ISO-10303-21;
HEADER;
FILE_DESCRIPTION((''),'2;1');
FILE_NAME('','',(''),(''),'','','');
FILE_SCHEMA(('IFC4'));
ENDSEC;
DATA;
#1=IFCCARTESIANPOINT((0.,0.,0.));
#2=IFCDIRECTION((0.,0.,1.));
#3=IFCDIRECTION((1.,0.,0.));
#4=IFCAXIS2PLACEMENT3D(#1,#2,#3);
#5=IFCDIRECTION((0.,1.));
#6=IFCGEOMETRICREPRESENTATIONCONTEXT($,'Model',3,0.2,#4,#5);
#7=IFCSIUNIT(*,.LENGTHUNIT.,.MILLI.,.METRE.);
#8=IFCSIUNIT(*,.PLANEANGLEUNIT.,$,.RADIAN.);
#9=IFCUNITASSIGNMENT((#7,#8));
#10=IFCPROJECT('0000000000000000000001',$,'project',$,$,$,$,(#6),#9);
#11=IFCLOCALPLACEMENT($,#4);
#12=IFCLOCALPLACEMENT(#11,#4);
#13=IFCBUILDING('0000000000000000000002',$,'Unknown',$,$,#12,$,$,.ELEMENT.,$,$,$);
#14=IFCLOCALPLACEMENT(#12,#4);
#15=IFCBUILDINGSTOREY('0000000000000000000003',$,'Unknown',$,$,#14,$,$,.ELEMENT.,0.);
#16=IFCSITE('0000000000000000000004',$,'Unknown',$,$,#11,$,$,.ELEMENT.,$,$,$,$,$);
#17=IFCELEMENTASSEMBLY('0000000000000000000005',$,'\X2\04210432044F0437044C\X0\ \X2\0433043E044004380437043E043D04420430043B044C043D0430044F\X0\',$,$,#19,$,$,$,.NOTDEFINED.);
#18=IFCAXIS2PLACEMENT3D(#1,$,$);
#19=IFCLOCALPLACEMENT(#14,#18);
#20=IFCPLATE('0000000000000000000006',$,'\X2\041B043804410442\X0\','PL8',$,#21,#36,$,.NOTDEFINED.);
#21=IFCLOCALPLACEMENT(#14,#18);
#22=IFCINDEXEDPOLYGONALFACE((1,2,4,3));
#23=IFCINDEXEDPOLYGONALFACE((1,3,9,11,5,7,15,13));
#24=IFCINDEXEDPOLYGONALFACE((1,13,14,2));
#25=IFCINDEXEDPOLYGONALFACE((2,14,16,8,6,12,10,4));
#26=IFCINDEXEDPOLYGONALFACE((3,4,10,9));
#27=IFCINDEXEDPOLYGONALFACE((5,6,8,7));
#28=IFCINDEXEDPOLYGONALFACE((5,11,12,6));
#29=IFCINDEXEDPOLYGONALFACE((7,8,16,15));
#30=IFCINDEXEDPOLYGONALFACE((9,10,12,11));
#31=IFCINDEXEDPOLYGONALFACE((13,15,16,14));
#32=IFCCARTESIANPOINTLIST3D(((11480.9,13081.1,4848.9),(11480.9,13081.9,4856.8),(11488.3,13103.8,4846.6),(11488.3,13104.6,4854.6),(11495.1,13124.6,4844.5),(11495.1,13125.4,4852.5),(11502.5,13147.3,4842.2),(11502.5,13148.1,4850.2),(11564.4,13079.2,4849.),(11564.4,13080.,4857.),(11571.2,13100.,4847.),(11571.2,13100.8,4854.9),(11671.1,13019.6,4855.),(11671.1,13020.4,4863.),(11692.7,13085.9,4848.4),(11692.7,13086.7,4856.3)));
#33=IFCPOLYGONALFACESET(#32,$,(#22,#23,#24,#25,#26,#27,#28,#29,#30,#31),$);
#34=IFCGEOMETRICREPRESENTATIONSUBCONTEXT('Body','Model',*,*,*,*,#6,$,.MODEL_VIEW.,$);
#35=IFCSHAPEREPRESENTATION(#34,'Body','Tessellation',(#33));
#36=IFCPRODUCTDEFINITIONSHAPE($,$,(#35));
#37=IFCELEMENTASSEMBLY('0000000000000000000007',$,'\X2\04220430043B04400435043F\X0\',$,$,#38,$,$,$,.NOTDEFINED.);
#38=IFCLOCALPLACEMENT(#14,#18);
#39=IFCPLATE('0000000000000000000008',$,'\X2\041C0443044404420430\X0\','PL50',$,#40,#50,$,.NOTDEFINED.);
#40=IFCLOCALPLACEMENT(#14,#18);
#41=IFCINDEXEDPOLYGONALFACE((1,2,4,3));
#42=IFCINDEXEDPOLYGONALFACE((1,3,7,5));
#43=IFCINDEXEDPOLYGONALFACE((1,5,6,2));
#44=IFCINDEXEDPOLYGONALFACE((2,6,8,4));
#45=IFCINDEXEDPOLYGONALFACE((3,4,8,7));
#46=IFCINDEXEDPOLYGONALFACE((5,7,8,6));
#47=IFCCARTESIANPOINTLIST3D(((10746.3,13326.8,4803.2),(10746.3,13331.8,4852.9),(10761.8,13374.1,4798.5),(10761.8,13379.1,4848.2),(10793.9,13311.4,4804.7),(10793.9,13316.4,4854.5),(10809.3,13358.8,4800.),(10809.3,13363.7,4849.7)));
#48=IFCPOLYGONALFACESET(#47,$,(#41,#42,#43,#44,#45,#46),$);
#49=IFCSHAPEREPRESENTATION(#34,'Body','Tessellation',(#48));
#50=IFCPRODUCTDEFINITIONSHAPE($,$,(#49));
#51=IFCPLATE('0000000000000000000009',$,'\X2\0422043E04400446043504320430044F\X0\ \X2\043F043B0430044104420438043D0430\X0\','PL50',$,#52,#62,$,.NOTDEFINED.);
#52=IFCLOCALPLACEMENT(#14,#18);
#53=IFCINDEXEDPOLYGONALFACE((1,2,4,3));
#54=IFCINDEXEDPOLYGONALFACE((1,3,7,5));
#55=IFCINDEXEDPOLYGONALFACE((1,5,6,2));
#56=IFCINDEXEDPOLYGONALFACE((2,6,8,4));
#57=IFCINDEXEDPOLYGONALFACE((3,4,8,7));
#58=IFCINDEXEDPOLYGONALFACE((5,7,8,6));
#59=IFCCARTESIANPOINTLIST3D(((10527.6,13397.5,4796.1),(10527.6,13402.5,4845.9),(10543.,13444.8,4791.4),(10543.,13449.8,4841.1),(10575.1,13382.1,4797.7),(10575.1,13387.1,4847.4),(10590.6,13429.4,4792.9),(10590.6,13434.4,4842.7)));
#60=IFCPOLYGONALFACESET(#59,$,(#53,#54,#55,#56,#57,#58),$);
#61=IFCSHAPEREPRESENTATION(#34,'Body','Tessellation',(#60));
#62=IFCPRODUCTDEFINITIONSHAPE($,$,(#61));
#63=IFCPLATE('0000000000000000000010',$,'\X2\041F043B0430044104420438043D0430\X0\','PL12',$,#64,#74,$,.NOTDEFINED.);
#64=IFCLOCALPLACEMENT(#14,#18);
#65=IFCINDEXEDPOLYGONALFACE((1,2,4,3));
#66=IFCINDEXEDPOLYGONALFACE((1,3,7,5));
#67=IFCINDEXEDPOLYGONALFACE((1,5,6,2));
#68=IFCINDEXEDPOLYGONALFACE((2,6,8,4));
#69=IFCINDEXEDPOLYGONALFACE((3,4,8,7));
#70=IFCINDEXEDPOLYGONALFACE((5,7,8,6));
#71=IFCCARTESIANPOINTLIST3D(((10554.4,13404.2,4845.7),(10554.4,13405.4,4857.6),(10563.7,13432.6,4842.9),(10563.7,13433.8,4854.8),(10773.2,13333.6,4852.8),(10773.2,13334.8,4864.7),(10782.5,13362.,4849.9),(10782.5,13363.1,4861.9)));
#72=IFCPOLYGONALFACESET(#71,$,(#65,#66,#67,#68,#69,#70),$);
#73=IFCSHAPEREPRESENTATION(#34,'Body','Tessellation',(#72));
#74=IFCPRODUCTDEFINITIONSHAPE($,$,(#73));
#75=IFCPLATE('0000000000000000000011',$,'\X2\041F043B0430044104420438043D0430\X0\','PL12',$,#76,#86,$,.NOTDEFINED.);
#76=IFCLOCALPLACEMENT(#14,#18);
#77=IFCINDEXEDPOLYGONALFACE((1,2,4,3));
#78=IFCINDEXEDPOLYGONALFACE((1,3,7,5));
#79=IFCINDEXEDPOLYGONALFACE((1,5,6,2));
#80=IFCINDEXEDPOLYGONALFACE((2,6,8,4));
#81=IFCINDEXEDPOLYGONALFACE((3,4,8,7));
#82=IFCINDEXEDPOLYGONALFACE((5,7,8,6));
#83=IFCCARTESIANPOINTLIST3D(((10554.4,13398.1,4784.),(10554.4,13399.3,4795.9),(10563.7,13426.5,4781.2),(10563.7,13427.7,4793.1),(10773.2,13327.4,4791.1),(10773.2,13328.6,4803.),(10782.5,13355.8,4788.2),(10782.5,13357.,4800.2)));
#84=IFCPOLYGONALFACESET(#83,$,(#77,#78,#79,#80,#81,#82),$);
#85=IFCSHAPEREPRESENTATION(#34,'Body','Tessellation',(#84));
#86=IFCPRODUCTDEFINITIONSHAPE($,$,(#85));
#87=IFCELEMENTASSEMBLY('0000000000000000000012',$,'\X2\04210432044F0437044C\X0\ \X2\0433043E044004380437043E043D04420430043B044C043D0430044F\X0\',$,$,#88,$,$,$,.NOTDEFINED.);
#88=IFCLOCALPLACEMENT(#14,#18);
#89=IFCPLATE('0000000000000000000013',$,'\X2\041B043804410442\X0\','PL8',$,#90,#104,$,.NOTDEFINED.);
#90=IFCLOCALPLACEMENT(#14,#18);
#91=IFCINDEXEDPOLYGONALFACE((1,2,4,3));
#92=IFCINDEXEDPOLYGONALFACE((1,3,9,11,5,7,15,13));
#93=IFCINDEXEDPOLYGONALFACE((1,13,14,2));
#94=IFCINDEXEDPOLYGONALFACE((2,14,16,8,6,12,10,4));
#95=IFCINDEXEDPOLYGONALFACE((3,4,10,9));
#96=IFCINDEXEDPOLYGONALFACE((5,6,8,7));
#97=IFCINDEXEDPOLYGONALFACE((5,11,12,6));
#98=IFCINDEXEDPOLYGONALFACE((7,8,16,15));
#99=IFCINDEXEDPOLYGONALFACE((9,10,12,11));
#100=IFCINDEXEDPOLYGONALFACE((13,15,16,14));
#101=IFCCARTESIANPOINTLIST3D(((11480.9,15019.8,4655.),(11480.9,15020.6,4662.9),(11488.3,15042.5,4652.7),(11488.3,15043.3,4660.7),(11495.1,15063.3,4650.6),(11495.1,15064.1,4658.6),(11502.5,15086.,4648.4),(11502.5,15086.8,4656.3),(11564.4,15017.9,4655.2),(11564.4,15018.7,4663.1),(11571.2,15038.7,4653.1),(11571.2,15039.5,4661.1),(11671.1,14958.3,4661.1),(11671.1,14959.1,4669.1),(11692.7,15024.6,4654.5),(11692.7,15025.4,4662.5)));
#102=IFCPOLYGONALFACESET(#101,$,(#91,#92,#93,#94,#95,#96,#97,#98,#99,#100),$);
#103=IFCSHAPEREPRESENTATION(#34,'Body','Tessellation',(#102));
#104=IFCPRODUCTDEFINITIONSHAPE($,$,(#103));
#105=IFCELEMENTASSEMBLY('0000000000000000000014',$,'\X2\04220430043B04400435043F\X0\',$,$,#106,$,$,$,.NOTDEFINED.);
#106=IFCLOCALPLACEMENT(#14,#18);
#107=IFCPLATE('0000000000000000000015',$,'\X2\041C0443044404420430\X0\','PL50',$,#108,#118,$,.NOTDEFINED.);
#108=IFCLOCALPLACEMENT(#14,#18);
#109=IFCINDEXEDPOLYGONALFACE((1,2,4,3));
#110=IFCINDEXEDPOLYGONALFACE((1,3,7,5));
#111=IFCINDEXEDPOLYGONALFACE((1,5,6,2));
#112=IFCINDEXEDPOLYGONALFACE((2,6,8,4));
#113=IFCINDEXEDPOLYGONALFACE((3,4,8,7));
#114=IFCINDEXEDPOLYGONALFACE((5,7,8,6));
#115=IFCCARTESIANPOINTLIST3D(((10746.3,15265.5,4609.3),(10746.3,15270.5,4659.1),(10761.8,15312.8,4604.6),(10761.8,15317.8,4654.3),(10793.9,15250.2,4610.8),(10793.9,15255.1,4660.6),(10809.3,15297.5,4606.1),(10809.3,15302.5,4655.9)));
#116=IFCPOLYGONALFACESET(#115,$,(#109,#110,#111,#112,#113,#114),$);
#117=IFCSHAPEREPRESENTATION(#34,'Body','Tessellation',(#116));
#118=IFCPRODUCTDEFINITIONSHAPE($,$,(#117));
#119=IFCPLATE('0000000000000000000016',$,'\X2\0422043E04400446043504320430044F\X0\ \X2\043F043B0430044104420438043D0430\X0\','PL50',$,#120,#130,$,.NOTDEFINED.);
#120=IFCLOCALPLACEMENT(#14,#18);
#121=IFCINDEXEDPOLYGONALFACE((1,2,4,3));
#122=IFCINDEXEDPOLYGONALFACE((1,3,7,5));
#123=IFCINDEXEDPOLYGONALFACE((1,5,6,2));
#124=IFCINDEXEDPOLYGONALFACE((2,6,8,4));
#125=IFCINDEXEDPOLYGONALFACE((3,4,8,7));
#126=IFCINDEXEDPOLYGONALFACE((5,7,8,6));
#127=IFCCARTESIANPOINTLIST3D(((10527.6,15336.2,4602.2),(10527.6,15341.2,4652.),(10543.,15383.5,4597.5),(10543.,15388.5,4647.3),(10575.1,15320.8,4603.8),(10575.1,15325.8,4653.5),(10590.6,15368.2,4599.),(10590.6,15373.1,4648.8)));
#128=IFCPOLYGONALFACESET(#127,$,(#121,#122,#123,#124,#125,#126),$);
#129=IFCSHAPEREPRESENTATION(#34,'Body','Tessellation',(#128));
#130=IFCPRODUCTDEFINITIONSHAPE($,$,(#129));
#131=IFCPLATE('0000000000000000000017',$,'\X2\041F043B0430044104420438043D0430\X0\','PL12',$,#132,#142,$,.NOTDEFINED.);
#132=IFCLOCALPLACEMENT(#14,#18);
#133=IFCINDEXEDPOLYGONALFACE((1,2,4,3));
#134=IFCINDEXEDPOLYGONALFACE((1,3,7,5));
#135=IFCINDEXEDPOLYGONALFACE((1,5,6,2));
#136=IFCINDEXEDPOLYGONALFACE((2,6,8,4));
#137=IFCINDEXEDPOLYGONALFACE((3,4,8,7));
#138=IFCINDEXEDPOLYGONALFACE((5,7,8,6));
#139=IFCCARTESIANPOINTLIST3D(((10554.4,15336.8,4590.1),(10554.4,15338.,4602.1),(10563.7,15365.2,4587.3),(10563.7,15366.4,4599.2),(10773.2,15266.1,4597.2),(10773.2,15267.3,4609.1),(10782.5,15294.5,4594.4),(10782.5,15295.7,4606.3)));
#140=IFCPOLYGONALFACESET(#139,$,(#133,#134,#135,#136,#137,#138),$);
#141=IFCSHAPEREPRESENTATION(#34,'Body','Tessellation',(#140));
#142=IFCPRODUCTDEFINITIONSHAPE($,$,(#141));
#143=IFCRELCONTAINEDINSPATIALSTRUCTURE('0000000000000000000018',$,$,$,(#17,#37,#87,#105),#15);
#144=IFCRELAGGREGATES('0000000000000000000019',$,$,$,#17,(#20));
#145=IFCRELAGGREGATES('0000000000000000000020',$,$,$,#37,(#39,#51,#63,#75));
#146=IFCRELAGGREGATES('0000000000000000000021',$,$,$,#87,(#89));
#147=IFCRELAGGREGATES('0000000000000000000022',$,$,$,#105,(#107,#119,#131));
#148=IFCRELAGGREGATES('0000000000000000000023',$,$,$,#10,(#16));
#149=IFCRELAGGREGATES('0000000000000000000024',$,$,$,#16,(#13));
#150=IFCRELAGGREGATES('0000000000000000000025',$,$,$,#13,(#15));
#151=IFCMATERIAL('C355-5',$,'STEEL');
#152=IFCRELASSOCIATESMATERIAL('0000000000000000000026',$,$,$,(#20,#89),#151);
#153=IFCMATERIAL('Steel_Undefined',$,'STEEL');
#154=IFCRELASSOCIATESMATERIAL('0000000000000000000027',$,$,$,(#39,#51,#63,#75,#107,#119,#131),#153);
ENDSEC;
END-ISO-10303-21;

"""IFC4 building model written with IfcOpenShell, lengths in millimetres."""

from ifc_helpers import new_model, si_unit, direction, frame, origin_with_axes, place, context, subcontext, project, spatial, line, indexed_curve, outline, extrude, material, element, aggregate, save


model = new_model("IFC4")

# Units and contexts
model_context = context("Model", 3, precision=0.2, world=origin_with_axes(), true_north=direction((0.0, 1.0)))
body_context = subcontext(model_context, "Body", "Model", "MODEL_VIEW")
ifc_project = project(units=[si_unit("LENGTHUNIT", "METRE", prefix="MILLI"), si_unit("PLANEANGLEUNIT", "RADIAN")], contexts=[model_context])

# Site, building, storey
site_placement = place(None, origin_with_axes())
site = spatial("IfcSite", under=ifc_project, at=site_placement, Name="Unknown", CompositionType="ELEMENT")
building_placement = place(site_placement, origin_with_axes())
building = spatial("IfcBuilding", under=site, at=building_placement, Name="Unknown", CompositionType="ELEMENT")
storey_placement = place(building_placement, origin_with_axes())
storey = spatial("IfcBuildingStorey", under=building, at=storey_placement, Name="Unknown", CompositionType="ELEMENT", Elevation=0.0)

# Shared definitions
ifc_material_1 = material(Name="C355-5", Category="STEEL")

# Shared definitions
ifc_material_2 = material(Name="Steel_Undefined", Category="STEEL")

# Element assembly, plate
assembly_1_placement = place(storey_placement, frame((10668.4, 13380.6, 4822.9), z_axis=(-0.308855, -0.946389, 0.094639), x_axis=(0.951109, -0.307322, 0.030732)))
assembly_1 = element("IfcElementAssembly", 1, at=assembly_1_placement, inside=storey, Name="Связь горизонтальная", PredefinedType="NOTDEFINED")
plate_1_placement = place(assembly_1_placement, frame((865.6, 0.0, -35.0), z_axis=(0.0, -1.0, 0.0), x_axis=(1.0, 0.0, 0.0)))
plate_1 = element("IfcPlate", 2, at=plate_1_placement, material=ifc_material_1, Name="Лист", Description="PL8", PredefinedType="NOTDEFINED", context=body_context, shape_type="SolidModel", body=[
    extrude(outline(indexed_curve([(0.0, 0.0), (200.0, 0.0), (200.0, 70.0), (0.0, 70.0), (0.0, 46.0), (80.0, 46.0), (80.0, 24.0), (0.0, 24.0)], segments=[line(1, 2, 3, 4, 5, 6, 7, 8, 1)])), frame((0.0, 0.0, 4.0), z_axis=(0.0, 0.0, 1.0), x_axis=(1.0, 0.0, 0.0)), (0.0, 0.0, -1.0), 8.0),
])
aggregate(assembly_1, [plate_1])

# Element assembly, plates
assembly_2_placement = place(storey_placement, frame((10770.1, 13324.1, 4853.7), z_axis=(-0.951109, 0.307322, -0.030732), x_axis=(0.308855, 0.946389, -0.094639)))
assembly_2 = element("IfcElementAssembly", 3, at=assembly_2_placement, inside=storey, Name="Талреп", PredefinedType="NOTDEFINED")
plate_2_placement = place(assembly_2_placement, origin_with_axes())
plate_2 = element("IfcPlate", 4, at=plate_2_placement, material=ifc_material_2, Name="Муфта", Description="PL50", PredefinedType="NOTDEFINED", context=body_context, shape_type="SolidModel", body=[
    extrude(outline(indexed_curve([(0.0, 0.0), (50.0, 0.0), (50.0, 50.0), (0.0, 50.0)], segments=[line(1, 2, 3, 4, 1)])), frame((0.0, 0.0, 25.0), z_axis=(0.0, 0.0, 1.0), x_axis=(1.0, 0.0, 0.0)), (0.0, 0.0, -1.0), 50.0),
])
plate_3_placement = place(assembly_2_placement, frame((0.0, 0.0, 230.0), z_axis=(0.0, 0.0, 1.0), x_axis=(1.0, 0.0, 0.0)))
plate_3 = element("IfcPlate", 5, at=plate_3_placement, material=ifc_material_2, Name="Торцевая пластина", Description="PL50", PredefinedType="NOTDEFINED", context=body_context, shape_type="SolidModel", body=[
    extrude(outline(indexed_curve([(0.0, 0.0), (50.0, 0.0), (50.0, 50.0), (0.0, 50.0)], segments=[line(1, 2, 3, 4, 1)])), frame((0.0, 0.0, 25.0), z_axis=(0.0, 0.0, 1.0), x_axis=(1.0, 0.0, 0.0)), (0.0, 0.0, -1.0), 50.0),
])
plate_4_placement = place(assembly_2_placement, frame((10.0, -6.0, 230.0), z_axis=(0.0, 1.0, 0.0), x_axis=(1.0, 0.0, 0.0)))
plate_4 = element("IfcPlate", 6, at=plate_4_placement, material=ifc_material_2, Name="Пластина", Description="PL12", PredefinedType="NOTDEFINED", context=body_context, shape_type="SolidModel", body=[
    extrude(outline(indexed_curve([(0.0, 0.0), (30.0, 0.0), (30.0, 230.0), (0.0, 230.0)], segments=[line(1, 2, 3, 4, 1)])), frame((0.0, 0.0, 6.0), z_axis=(0.0, 0.0, 1.0), x_axis=(1.0, 0.0, 0.0)), (0.0, 0.0, -1.0), 12.0),
])
plate_5_placement = place(assembly_2_placement, frame((10.0, 56.0, 230.0), z_axis=(0.0, 1.0, 0.0), x_axis=(1.0, 0.0, 0.0)))
plate_5 = element("IfcPlate", 7, at=plate_5_placement, material=ifc_material_2, Name="Пластина", Description="PL12", PredefinedType="NOTDEFINED", context=body_context, shape_type="SolidModel", body=[
    extrude(outline(indexed_curve([(0.0, 0.0), (30.0, 0.0), (30.0, 230.0), (0.0, 230.0)], segments=[line(1, 2, 3, 4, 1)])), frame((0.0, 0.0, 6.0), z_axis=(0.0, 0.0, 1.0), x_axis=(1.0, 0.0, 0.0)), (0.0, 0.0, -1.0), 12.0),
])
aggregate(assembly_2, [plate_2, plate_3, plate_4, plate_5])

# Element assembly, plate
assembly_3_placement = place(storey_placement, frame((10668.4, 15319.3, 4629.1), z_axis=(-0.308855, -0.946389, 0.094639), x_axis=(0.951109, -0.307322, 0.030732)))
assembly_3 = element("IfcElementAssembly", 8, at=assembly_3_placement, inside=storey, Name="Связь горизонтальная", PredefinedType="NOTDEFINED")
plate_6_placement = place(assembly_3_placement, frame((865.6, 0.0, -35.0), z_axis=(0.0, -1.0, 0.0), x_axis=(1.0, 0.0, 0.0)))
plate_6 = element("IfcPlate", 9, at=plate_6_placement, material=ifc_material_1, Name="Лист", Description="PL8", PredefinedType="NOTDEFINED", context=body_context, shape_type="SolidModel", body=[
    extrude(outline(indexed_curve([(0.0, 0.0), (200.0, 0.0), (200.0, 70.0), (0.0, 70.0), (0.0, 46.0), (80.0, 46.0), (80.0, 24.0), (0.0, 24.0)], segments=[line(1, 2, 3, 4, 5, 6, 7, 8, 1)])), frame((0.0, 0.0, 4.0), z_axis=(0.0, 0.0, 1.0), x_axis=(1.0, 0.0, 0.0)), (0.0, 0.0, -1.0), 8.0),
])
aggregate(assembly_3, [plate_6])

# Element assembly, plates
assembly_4_placement = place(storey_placement, frame((10770.1, 15262.8, 4659.8), z_axis=(-0.951109, 0.307322, -0.030732), x_axis=(0.308855, 0.946389, -0.094639)))
assembly_4 = element("IfcElementAssembly", 10, at=assembly_4_placement, inside=storey, Name="Талреп", PredefinedType="NOTDEFINED")
plate_7_placement = place(assembly_4_placement, origin_with_axes())
plate_7 = element("IfcPlate", 11, at=plate_7_placement, material=ifc_material_2, Name="Муфта", Description="PL50", PredefinedType="NOTDEFINED", context=body_context, shape_type="SolidModel", body=[
    extrude(outline(indexed_curve([(0.0, 0.0), (50.0, 0.0), (50.0, 50.0), (0.0, 50.0)], segments=[line(1, 2, 3, 4, 1)])), frame((0.0, 0.0, 25.0), z_axis=(0.0, 0.0, 1.0), x_axis=(1.0, 0.0, 0.0)), (0.0, 0.0, -1.0), 50.0),
])
plate_8_placement = place(assembly_4_placement, frame((0.0, 0.0, 230.0), z_axis=(0.0, 0.0, 1.0), x_axis=(1.0, 0.0, 0.0)))
plate_8 = element("IfcPlate", 12, at=plate_8_placement, material=ifc_material_2, Name="Торцевая пластина", Description="PL50", PredefinedType="NOTDEFINED", context=body_context, shape_type="SolidModel", body=[
    extrude(outline(indexed_curve([(0.0, 0.0), (50.0, 0.0), (50.0, 50.0), (0.0, 50.0)], segments=[line(1, 2, 3, 4, 1)])), frame((0.0, 0.0, 25.0), z_axis=(0.0, 0.0, 1.0), x_axis=(1.0, 0.0, 0.0)), (0.0, 0.0, -1.0), 50.0),
])
plate_9_placement = place(assembly_4_placement, frame((10.0, 56.0, 230.0), z_axis=(0.0, 1.0, 0.0), x_axis=(1.0, 0.0, 0.0)))
plate_9 = element("IfcPlate", 13, at=plate_9_placement, material=ifc_material_2, Name="Пластина", Description="PL12", PredefinedType="NOTDEFINED", context=body_context, shape_type="SolidModel", body=[
    extrude(outline(indexed_curve([(0.0, 0.0), (30.0, 0.0), (30.0, 230.0), (0.0, 230.0)], segments=[line(1, 2, 3, 4, 1)])), frame((0.0, 0.0, 6.0), z_axis=(0.0, 0.0, 1.0), x_axis=(1.0, 0.0, 0.0)), (0.0, 0.0, -1.0), 12.0),
])
aggregate(assembly_4, [plate_7, plate_8, plate_9])

save(model, "model.ifc")
